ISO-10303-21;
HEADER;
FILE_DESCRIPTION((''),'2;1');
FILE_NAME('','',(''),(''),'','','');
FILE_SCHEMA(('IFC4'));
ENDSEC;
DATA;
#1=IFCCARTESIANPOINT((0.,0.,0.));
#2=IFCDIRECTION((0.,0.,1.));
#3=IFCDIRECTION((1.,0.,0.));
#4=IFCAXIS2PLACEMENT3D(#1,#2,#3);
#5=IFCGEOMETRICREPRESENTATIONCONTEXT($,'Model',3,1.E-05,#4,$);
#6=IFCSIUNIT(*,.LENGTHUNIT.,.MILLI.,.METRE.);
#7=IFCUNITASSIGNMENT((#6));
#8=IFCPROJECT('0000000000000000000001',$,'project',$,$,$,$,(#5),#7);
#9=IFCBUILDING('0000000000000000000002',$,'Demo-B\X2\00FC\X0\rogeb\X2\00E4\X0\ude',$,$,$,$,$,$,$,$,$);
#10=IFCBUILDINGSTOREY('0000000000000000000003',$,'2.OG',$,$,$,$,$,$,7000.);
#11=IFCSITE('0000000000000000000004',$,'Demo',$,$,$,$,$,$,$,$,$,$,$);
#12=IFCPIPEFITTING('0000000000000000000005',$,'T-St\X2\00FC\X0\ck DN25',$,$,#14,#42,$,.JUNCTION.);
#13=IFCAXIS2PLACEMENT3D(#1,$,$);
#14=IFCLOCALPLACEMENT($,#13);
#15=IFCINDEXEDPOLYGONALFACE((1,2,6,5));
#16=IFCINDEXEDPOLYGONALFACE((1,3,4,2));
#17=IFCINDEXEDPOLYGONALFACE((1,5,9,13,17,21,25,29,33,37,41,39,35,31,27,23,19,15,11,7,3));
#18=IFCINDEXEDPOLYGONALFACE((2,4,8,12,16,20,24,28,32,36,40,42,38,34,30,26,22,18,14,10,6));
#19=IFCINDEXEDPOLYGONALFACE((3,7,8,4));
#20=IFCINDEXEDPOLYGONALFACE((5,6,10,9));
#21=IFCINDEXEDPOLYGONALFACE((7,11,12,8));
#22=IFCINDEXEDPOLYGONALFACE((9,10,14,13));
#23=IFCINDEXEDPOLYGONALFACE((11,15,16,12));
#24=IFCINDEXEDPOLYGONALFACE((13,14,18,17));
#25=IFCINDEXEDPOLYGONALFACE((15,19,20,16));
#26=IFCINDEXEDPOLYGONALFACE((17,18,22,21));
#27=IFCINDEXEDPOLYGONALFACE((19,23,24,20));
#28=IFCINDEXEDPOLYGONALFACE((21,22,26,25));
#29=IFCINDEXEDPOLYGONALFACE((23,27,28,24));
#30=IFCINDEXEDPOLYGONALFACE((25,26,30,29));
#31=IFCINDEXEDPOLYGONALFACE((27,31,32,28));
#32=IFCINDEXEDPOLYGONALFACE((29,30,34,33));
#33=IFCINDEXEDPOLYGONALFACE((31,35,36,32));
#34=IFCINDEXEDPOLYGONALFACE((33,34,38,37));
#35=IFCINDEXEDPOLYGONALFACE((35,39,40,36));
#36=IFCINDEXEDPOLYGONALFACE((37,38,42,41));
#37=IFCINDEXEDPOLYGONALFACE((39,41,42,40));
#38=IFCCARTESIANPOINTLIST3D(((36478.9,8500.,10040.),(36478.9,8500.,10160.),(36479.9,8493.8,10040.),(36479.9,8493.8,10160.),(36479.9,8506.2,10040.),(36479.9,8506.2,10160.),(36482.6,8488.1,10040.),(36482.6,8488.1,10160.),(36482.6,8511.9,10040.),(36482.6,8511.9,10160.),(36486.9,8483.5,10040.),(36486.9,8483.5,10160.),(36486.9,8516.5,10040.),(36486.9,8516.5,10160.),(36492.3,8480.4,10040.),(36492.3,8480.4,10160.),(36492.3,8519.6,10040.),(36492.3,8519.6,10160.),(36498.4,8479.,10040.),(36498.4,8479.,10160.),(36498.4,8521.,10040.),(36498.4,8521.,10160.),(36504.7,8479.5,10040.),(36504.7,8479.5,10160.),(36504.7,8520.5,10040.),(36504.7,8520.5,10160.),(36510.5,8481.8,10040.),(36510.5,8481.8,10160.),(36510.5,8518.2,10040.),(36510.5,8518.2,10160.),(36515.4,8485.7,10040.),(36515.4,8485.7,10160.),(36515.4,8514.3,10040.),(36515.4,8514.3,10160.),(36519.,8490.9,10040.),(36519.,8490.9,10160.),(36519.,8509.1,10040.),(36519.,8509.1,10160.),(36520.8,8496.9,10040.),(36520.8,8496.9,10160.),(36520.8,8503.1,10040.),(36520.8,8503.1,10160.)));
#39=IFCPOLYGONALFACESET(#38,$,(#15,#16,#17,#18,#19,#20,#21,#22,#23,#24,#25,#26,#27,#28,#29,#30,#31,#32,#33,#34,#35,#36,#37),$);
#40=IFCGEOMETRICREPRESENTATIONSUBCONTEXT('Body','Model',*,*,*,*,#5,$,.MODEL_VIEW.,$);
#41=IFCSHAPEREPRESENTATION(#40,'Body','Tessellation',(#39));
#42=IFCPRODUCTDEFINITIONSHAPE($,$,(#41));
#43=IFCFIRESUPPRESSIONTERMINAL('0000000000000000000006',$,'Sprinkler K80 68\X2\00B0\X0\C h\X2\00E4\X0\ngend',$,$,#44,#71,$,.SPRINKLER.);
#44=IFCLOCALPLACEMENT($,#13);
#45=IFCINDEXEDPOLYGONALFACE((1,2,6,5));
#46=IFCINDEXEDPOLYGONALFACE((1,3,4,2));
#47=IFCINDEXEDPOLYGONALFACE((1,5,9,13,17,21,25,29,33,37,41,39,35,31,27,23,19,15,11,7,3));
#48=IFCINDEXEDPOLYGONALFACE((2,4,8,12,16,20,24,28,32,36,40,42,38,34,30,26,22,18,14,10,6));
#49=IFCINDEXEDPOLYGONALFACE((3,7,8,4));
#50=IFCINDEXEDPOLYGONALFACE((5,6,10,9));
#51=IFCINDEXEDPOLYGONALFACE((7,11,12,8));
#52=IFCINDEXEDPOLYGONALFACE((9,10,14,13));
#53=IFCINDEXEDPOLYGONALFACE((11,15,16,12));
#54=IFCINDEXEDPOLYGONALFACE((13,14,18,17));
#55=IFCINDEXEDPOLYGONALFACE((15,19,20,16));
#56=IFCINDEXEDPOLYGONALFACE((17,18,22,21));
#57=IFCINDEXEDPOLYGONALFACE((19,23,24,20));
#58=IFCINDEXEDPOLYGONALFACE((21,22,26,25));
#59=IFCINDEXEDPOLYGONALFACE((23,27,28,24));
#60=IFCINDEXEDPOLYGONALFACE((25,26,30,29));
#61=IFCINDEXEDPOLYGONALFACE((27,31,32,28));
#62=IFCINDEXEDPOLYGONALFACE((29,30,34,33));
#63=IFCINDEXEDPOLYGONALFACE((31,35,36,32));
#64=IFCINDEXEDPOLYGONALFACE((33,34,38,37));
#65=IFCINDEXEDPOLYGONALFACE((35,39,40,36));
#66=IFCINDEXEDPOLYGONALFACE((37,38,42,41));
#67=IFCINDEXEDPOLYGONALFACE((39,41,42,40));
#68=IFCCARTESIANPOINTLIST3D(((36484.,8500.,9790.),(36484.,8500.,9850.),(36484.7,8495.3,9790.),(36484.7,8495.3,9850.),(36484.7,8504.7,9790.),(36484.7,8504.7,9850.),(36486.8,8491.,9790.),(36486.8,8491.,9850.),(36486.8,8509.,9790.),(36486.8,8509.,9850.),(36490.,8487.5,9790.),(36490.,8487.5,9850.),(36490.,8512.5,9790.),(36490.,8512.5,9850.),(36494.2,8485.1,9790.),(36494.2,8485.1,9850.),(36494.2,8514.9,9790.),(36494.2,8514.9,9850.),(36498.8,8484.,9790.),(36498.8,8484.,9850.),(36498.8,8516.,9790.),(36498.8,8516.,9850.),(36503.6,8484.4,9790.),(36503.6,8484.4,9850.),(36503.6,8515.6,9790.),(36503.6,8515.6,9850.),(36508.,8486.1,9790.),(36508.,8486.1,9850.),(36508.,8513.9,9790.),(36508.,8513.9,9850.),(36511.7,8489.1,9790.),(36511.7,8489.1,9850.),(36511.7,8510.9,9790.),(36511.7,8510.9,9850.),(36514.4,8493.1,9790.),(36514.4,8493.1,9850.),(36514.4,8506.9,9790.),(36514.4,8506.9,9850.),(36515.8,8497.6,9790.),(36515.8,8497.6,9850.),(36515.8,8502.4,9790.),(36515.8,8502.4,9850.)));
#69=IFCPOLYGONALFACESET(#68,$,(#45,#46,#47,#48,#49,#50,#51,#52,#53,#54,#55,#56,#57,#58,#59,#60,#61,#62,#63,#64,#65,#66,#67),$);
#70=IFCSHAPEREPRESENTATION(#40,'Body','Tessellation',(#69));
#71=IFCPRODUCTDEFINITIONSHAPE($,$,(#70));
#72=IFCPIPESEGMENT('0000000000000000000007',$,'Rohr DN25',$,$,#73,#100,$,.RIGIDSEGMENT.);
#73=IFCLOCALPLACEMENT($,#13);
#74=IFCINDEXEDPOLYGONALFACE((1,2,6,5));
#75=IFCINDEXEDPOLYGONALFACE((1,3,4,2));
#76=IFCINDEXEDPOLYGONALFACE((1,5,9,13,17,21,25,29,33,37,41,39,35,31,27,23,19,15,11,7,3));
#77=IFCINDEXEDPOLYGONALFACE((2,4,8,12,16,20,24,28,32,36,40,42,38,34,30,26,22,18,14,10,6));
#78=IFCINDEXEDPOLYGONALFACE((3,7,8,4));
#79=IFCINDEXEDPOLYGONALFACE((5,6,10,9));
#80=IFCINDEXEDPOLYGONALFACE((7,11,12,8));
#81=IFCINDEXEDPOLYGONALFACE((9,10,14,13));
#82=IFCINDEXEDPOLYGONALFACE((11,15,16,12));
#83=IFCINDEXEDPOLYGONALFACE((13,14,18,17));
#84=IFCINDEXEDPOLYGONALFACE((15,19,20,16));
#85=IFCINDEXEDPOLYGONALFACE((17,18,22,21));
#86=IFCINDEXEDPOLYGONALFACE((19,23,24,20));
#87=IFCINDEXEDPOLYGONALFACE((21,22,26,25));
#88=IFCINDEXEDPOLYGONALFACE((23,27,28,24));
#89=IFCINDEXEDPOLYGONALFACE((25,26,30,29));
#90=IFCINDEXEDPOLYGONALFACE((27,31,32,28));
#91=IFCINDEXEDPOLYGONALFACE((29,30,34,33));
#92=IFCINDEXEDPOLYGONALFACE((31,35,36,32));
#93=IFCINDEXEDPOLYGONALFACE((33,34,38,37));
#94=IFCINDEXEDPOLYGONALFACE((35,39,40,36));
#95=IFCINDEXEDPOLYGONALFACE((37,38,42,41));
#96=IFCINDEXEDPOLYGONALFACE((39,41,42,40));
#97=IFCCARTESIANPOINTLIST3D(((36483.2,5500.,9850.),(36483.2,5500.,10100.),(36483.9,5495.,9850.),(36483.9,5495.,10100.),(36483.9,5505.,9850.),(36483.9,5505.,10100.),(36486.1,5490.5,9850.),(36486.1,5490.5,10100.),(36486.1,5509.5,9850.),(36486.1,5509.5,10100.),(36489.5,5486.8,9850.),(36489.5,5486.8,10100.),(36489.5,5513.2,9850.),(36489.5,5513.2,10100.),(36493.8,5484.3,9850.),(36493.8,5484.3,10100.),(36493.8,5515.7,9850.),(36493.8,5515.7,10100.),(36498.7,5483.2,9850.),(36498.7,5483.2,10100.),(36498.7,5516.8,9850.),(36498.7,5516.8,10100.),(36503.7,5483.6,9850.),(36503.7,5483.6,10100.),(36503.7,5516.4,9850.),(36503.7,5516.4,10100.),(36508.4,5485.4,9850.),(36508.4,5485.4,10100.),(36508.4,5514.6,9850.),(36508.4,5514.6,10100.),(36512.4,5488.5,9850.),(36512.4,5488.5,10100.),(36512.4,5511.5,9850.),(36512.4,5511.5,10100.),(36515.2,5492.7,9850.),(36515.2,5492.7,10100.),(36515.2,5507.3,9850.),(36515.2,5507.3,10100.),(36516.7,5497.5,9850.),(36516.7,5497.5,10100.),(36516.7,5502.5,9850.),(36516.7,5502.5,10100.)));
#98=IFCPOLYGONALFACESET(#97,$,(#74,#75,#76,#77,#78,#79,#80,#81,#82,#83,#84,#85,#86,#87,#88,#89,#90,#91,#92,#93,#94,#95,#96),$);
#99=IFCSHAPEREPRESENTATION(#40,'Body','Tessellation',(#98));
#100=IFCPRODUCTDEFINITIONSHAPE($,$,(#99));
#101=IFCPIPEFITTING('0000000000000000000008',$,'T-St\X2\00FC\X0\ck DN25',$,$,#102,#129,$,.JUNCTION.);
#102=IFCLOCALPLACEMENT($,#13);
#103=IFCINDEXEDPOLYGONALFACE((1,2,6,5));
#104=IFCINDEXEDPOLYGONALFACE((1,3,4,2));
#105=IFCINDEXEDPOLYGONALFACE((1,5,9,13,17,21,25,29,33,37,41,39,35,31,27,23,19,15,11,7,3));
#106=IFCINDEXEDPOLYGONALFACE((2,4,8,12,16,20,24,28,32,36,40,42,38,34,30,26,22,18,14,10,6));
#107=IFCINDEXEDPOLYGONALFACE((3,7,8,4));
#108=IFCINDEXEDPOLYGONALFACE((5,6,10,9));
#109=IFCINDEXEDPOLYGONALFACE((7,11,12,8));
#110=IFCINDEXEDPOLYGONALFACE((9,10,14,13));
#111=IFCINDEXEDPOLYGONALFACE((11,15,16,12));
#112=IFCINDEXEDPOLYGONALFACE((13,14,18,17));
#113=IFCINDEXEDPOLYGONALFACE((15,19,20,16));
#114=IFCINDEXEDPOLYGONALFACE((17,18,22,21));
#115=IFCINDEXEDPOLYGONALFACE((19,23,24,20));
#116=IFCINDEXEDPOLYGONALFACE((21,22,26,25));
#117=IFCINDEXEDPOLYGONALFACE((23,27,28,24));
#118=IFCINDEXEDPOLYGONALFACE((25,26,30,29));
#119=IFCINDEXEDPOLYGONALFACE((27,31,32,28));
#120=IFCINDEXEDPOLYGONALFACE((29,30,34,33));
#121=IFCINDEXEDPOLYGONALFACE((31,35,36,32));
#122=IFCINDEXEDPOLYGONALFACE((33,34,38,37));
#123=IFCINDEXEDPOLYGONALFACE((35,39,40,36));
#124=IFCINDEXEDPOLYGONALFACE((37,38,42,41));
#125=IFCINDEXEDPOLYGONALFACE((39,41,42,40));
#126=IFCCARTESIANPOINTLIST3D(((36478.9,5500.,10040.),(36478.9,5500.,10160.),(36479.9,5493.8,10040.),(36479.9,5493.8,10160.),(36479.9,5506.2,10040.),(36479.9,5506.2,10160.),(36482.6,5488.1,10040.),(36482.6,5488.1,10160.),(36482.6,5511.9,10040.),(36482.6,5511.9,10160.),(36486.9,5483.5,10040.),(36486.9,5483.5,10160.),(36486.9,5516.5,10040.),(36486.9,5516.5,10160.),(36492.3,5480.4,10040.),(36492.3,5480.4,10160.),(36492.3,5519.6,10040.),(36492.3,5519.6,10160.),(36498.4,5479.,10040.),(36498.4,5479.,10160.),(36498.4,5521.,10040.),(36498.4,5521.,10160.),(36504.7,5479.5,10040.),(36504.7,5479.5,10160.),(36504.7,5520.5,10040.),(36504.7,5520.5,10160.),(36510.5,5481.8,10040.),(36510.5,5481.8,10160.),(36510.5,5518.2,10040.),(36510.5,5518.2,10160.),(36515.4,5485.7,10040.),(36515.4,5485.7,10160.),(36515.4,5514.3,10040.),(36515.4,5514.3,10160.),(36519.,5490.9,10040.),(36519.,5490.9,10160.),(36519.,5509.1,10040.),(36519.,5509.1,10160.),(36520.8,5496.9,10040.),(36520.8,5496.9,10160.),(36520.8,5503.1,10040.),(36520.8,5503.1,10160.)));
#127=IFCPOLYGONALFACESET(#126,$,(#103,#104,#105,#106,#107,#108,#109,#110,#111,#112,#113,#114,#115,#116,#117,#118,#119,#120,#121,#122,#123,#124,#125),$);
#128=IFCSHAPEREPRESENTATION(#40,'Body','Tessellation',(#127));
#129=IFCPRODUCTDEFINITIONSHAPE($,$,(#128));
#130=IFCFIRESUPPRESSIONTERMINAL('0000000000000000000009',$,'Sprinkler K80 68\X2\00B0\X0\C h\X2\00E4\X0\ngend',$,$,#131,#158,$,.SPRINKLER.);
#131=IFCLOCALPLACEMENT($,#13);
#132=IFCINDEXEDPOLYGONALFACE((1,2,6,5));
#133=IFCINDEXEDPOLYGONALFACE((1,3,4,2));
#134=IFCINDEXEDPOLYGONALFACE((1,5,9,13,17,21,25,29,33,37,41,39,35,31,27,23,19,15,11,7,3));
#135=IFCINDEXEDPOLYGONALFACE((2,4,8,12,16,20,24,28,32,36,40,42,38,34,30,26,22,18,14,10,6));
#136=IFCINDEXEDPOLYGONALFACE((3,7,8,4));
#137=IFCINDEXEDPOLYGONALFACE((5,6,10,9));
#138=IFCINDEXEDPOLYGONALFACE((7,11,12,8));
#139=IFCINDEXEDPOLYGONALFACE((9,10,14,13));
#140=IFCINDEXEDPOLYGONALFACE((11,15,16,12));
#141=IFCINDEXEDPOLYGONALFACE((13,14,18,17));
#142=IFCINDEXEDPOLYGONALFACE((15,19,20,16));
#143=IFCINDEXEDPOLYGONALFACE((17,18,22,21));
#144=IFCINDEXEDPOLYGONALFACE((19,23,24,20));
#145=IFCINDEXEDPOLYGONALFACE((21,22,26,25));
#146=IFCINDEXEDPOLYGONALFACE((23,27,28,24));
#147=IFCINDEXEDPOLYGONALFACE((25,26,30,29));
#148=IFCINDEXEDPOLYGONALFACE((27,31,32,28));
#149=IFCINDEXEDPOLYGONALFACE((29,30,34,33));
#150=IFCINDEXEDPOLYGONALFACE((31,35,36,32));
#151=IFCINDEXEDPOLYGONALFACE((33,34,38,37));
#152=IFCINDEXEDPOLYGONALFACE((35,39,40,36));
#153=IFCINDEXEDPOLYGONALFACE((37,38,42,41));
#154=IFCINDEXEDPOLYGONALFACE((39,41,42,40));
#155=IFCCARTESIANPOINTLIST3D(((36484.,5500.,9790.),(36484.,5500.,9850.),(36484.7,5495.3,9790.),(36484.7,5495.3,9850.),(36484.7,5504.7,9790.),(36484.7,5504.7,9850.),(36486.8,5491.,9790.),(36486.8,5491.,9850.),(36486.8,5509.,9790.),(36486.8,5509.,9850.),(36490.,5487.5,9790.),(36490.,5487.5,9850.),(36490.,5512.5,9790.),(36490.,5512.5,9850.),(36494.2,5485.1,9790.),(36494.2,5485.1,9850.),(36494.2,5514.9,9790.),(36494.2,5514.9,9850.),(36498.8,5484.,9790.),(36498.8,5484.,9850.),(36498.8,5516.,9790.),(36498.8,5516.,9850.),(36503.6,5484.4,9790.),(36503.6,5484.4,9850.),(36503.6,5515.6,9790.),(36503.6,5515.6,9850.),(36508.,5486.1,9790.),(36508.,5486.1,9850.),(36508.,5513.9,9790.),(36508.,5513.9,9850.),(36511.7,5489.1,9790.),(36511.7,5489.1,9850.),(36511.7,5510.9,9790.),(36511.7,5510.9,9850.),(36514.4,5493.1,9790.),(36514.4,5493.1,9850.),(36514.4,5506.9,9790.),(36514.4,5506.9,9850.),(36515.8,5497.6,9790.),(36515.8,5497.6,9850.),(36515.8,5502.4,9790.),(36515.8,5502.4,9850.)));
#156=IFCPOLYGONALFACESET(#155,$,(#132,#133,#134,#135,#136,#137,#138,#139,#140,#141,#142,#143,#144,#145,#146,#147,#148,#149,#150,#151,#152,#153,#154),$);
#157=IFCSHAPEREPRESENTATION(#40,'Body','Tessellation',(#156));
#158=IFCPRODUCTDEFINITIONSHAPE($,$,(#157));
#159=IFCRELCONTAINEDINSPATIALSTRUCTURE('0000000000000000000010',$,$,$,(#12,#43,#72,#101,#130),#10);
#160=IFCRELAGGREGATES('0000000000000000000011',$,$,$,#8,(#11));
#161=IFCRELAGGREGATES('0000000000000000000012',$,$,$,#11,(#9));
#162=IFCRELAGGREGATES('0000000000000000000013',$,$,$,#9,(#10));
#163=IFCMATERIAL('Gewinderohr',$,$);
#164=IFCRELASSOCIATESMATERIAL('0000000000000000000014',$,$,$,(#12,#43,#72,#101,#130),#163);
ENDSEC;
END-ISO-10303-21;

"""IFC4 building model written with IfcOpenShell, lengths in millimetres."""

from ifc_helpers import new_model, si_unit, frame, origin_with_axes, place, context, subcontext, project, spatial, circle, extrude, material, element, save


model = new_model("IFC4")

# Units and contexts
model_context = context("Model", 3, precision=1e-05, world=origin_with_axes())
body_context = subcontext(model_context, "Body", "Model", "MODEL_VIEW")
ifc_project = project(units=[si_unit("LENGTHUNIT", "METRE", prefix="MILLI")], contexts=[model_context])

# Site, building, storey
site = spatial("IfcSite", under=ifc_project, Name="Demo")
building = spatial("IfcBuilding", under=site, Name="Demo-Bürogebäude")
storey = spatial("IfcBuildingStorey", under=building, Name="2.OG", Elevation=7000.0)

# Shared definitions
ifc_material_1 = material(Name="Gewinderohr")

# Pipe fitting
pipe_fitting_1_placement = place(None, frame((36500.0, 8500.0, 10160.0), z_axis=(0.0, 0.0, -1.0), x_axis=(-1.0, 0.0, 0.0)))
element("IfcPipeFitting", 1, at=pipe_fitting_1_placement, inside=storey, material=ifc_material_1, Name="T-Stück DN25", PredefinedType="JUNCTION", context=body_context, shape_type="SweptSolid", body=[
    extrude(circle(Radius=21.1), origin_with_axes(), (0.0, 0.0, 1.0), 120.0),
])

# Fire suppression terminal
fire_suppression_terminal_1_placement = place(None, frame((36500.0, 8500.0, 9850.0), z_axis=(0.0, 0.0, -1.0), x_axis=(-1.0, 0.0, 0.0)))
element("IfcFireSuppressionTerminal", 2, at=fire_suppression_terminal_1_placement, inside=storey, material=ifc_material_1, Name="Sprinkler K80 68°C hängend", PredefinedType="SPRINKLER", context=body_context, shape_type="SweptSolid", body=[
    extrude(circle(Radius=16.0), origin_with_axes(), (0.0, 0.0, 1.0), 60.0),
])

# Pipe segment
pipe_segment_1_placement = place(None, frame((36500.0, 5500.0, 10100.0), z_axis=(0.0, 0.0, -1.0), x_axis=(-1.0, 0.0, 0.0)))
element("IfcPipeSegment", 3, at=pipe_segment_1_placement, inside=storey, material=ifc_material_1, Name="Rohr DN25", PredefinedType="RIGIDSEGMENT", context=body_context, shape_type="SweptSolid", body=[
    extrude(circle(Radius=16.9), origin_with_axes(), (0.0, 0.0, 1.0), 250.0),
])

# Pipe fitting
pipe_fitting_2_placement = place(None, frame((36500.0, 5500.0, 10160.0), z_axis=(0.0, 0.0, -1.0), x_axis=(-1.0, 0.0, 0.0)))
element("IfcPipeFitting", 4, at=pipe_fitting_2_placement, inside=storey, material=ifc_material_1, Name="T-Stück DN25", PredefinedType="JUNCTION", context=body_context, shape_type="SweptSolid", body=[
    extrude(circle(Radius=21.1), origin_with_axes(), (0.0, 0.0, 1.0), 120.0),
])

# Fire suppression terminal
fire_suppression_terminal_2_placement = place(None, frame((36500.0, 5500.0, 9850.0), z_axis=(0.0, 0.0, -1.0), x_axis=(-1.0, 0.0, 0.0)))
element("IfcFireSuppressionTerminal", 5, at=fire_suppression_terminal_2_placement, inside=storey, material=ifc_material_1, Name="Sprinkler K80 68°C hängend", PredefinedType="SPRINKLER", context=body_context, shape_type="SweptSolid", body=[
    extrude(circle(Radius=16.0), origin_with_axes(), (0.0, 0.0, 1.0), 60.0),
])

save(model, "model.ifc")
